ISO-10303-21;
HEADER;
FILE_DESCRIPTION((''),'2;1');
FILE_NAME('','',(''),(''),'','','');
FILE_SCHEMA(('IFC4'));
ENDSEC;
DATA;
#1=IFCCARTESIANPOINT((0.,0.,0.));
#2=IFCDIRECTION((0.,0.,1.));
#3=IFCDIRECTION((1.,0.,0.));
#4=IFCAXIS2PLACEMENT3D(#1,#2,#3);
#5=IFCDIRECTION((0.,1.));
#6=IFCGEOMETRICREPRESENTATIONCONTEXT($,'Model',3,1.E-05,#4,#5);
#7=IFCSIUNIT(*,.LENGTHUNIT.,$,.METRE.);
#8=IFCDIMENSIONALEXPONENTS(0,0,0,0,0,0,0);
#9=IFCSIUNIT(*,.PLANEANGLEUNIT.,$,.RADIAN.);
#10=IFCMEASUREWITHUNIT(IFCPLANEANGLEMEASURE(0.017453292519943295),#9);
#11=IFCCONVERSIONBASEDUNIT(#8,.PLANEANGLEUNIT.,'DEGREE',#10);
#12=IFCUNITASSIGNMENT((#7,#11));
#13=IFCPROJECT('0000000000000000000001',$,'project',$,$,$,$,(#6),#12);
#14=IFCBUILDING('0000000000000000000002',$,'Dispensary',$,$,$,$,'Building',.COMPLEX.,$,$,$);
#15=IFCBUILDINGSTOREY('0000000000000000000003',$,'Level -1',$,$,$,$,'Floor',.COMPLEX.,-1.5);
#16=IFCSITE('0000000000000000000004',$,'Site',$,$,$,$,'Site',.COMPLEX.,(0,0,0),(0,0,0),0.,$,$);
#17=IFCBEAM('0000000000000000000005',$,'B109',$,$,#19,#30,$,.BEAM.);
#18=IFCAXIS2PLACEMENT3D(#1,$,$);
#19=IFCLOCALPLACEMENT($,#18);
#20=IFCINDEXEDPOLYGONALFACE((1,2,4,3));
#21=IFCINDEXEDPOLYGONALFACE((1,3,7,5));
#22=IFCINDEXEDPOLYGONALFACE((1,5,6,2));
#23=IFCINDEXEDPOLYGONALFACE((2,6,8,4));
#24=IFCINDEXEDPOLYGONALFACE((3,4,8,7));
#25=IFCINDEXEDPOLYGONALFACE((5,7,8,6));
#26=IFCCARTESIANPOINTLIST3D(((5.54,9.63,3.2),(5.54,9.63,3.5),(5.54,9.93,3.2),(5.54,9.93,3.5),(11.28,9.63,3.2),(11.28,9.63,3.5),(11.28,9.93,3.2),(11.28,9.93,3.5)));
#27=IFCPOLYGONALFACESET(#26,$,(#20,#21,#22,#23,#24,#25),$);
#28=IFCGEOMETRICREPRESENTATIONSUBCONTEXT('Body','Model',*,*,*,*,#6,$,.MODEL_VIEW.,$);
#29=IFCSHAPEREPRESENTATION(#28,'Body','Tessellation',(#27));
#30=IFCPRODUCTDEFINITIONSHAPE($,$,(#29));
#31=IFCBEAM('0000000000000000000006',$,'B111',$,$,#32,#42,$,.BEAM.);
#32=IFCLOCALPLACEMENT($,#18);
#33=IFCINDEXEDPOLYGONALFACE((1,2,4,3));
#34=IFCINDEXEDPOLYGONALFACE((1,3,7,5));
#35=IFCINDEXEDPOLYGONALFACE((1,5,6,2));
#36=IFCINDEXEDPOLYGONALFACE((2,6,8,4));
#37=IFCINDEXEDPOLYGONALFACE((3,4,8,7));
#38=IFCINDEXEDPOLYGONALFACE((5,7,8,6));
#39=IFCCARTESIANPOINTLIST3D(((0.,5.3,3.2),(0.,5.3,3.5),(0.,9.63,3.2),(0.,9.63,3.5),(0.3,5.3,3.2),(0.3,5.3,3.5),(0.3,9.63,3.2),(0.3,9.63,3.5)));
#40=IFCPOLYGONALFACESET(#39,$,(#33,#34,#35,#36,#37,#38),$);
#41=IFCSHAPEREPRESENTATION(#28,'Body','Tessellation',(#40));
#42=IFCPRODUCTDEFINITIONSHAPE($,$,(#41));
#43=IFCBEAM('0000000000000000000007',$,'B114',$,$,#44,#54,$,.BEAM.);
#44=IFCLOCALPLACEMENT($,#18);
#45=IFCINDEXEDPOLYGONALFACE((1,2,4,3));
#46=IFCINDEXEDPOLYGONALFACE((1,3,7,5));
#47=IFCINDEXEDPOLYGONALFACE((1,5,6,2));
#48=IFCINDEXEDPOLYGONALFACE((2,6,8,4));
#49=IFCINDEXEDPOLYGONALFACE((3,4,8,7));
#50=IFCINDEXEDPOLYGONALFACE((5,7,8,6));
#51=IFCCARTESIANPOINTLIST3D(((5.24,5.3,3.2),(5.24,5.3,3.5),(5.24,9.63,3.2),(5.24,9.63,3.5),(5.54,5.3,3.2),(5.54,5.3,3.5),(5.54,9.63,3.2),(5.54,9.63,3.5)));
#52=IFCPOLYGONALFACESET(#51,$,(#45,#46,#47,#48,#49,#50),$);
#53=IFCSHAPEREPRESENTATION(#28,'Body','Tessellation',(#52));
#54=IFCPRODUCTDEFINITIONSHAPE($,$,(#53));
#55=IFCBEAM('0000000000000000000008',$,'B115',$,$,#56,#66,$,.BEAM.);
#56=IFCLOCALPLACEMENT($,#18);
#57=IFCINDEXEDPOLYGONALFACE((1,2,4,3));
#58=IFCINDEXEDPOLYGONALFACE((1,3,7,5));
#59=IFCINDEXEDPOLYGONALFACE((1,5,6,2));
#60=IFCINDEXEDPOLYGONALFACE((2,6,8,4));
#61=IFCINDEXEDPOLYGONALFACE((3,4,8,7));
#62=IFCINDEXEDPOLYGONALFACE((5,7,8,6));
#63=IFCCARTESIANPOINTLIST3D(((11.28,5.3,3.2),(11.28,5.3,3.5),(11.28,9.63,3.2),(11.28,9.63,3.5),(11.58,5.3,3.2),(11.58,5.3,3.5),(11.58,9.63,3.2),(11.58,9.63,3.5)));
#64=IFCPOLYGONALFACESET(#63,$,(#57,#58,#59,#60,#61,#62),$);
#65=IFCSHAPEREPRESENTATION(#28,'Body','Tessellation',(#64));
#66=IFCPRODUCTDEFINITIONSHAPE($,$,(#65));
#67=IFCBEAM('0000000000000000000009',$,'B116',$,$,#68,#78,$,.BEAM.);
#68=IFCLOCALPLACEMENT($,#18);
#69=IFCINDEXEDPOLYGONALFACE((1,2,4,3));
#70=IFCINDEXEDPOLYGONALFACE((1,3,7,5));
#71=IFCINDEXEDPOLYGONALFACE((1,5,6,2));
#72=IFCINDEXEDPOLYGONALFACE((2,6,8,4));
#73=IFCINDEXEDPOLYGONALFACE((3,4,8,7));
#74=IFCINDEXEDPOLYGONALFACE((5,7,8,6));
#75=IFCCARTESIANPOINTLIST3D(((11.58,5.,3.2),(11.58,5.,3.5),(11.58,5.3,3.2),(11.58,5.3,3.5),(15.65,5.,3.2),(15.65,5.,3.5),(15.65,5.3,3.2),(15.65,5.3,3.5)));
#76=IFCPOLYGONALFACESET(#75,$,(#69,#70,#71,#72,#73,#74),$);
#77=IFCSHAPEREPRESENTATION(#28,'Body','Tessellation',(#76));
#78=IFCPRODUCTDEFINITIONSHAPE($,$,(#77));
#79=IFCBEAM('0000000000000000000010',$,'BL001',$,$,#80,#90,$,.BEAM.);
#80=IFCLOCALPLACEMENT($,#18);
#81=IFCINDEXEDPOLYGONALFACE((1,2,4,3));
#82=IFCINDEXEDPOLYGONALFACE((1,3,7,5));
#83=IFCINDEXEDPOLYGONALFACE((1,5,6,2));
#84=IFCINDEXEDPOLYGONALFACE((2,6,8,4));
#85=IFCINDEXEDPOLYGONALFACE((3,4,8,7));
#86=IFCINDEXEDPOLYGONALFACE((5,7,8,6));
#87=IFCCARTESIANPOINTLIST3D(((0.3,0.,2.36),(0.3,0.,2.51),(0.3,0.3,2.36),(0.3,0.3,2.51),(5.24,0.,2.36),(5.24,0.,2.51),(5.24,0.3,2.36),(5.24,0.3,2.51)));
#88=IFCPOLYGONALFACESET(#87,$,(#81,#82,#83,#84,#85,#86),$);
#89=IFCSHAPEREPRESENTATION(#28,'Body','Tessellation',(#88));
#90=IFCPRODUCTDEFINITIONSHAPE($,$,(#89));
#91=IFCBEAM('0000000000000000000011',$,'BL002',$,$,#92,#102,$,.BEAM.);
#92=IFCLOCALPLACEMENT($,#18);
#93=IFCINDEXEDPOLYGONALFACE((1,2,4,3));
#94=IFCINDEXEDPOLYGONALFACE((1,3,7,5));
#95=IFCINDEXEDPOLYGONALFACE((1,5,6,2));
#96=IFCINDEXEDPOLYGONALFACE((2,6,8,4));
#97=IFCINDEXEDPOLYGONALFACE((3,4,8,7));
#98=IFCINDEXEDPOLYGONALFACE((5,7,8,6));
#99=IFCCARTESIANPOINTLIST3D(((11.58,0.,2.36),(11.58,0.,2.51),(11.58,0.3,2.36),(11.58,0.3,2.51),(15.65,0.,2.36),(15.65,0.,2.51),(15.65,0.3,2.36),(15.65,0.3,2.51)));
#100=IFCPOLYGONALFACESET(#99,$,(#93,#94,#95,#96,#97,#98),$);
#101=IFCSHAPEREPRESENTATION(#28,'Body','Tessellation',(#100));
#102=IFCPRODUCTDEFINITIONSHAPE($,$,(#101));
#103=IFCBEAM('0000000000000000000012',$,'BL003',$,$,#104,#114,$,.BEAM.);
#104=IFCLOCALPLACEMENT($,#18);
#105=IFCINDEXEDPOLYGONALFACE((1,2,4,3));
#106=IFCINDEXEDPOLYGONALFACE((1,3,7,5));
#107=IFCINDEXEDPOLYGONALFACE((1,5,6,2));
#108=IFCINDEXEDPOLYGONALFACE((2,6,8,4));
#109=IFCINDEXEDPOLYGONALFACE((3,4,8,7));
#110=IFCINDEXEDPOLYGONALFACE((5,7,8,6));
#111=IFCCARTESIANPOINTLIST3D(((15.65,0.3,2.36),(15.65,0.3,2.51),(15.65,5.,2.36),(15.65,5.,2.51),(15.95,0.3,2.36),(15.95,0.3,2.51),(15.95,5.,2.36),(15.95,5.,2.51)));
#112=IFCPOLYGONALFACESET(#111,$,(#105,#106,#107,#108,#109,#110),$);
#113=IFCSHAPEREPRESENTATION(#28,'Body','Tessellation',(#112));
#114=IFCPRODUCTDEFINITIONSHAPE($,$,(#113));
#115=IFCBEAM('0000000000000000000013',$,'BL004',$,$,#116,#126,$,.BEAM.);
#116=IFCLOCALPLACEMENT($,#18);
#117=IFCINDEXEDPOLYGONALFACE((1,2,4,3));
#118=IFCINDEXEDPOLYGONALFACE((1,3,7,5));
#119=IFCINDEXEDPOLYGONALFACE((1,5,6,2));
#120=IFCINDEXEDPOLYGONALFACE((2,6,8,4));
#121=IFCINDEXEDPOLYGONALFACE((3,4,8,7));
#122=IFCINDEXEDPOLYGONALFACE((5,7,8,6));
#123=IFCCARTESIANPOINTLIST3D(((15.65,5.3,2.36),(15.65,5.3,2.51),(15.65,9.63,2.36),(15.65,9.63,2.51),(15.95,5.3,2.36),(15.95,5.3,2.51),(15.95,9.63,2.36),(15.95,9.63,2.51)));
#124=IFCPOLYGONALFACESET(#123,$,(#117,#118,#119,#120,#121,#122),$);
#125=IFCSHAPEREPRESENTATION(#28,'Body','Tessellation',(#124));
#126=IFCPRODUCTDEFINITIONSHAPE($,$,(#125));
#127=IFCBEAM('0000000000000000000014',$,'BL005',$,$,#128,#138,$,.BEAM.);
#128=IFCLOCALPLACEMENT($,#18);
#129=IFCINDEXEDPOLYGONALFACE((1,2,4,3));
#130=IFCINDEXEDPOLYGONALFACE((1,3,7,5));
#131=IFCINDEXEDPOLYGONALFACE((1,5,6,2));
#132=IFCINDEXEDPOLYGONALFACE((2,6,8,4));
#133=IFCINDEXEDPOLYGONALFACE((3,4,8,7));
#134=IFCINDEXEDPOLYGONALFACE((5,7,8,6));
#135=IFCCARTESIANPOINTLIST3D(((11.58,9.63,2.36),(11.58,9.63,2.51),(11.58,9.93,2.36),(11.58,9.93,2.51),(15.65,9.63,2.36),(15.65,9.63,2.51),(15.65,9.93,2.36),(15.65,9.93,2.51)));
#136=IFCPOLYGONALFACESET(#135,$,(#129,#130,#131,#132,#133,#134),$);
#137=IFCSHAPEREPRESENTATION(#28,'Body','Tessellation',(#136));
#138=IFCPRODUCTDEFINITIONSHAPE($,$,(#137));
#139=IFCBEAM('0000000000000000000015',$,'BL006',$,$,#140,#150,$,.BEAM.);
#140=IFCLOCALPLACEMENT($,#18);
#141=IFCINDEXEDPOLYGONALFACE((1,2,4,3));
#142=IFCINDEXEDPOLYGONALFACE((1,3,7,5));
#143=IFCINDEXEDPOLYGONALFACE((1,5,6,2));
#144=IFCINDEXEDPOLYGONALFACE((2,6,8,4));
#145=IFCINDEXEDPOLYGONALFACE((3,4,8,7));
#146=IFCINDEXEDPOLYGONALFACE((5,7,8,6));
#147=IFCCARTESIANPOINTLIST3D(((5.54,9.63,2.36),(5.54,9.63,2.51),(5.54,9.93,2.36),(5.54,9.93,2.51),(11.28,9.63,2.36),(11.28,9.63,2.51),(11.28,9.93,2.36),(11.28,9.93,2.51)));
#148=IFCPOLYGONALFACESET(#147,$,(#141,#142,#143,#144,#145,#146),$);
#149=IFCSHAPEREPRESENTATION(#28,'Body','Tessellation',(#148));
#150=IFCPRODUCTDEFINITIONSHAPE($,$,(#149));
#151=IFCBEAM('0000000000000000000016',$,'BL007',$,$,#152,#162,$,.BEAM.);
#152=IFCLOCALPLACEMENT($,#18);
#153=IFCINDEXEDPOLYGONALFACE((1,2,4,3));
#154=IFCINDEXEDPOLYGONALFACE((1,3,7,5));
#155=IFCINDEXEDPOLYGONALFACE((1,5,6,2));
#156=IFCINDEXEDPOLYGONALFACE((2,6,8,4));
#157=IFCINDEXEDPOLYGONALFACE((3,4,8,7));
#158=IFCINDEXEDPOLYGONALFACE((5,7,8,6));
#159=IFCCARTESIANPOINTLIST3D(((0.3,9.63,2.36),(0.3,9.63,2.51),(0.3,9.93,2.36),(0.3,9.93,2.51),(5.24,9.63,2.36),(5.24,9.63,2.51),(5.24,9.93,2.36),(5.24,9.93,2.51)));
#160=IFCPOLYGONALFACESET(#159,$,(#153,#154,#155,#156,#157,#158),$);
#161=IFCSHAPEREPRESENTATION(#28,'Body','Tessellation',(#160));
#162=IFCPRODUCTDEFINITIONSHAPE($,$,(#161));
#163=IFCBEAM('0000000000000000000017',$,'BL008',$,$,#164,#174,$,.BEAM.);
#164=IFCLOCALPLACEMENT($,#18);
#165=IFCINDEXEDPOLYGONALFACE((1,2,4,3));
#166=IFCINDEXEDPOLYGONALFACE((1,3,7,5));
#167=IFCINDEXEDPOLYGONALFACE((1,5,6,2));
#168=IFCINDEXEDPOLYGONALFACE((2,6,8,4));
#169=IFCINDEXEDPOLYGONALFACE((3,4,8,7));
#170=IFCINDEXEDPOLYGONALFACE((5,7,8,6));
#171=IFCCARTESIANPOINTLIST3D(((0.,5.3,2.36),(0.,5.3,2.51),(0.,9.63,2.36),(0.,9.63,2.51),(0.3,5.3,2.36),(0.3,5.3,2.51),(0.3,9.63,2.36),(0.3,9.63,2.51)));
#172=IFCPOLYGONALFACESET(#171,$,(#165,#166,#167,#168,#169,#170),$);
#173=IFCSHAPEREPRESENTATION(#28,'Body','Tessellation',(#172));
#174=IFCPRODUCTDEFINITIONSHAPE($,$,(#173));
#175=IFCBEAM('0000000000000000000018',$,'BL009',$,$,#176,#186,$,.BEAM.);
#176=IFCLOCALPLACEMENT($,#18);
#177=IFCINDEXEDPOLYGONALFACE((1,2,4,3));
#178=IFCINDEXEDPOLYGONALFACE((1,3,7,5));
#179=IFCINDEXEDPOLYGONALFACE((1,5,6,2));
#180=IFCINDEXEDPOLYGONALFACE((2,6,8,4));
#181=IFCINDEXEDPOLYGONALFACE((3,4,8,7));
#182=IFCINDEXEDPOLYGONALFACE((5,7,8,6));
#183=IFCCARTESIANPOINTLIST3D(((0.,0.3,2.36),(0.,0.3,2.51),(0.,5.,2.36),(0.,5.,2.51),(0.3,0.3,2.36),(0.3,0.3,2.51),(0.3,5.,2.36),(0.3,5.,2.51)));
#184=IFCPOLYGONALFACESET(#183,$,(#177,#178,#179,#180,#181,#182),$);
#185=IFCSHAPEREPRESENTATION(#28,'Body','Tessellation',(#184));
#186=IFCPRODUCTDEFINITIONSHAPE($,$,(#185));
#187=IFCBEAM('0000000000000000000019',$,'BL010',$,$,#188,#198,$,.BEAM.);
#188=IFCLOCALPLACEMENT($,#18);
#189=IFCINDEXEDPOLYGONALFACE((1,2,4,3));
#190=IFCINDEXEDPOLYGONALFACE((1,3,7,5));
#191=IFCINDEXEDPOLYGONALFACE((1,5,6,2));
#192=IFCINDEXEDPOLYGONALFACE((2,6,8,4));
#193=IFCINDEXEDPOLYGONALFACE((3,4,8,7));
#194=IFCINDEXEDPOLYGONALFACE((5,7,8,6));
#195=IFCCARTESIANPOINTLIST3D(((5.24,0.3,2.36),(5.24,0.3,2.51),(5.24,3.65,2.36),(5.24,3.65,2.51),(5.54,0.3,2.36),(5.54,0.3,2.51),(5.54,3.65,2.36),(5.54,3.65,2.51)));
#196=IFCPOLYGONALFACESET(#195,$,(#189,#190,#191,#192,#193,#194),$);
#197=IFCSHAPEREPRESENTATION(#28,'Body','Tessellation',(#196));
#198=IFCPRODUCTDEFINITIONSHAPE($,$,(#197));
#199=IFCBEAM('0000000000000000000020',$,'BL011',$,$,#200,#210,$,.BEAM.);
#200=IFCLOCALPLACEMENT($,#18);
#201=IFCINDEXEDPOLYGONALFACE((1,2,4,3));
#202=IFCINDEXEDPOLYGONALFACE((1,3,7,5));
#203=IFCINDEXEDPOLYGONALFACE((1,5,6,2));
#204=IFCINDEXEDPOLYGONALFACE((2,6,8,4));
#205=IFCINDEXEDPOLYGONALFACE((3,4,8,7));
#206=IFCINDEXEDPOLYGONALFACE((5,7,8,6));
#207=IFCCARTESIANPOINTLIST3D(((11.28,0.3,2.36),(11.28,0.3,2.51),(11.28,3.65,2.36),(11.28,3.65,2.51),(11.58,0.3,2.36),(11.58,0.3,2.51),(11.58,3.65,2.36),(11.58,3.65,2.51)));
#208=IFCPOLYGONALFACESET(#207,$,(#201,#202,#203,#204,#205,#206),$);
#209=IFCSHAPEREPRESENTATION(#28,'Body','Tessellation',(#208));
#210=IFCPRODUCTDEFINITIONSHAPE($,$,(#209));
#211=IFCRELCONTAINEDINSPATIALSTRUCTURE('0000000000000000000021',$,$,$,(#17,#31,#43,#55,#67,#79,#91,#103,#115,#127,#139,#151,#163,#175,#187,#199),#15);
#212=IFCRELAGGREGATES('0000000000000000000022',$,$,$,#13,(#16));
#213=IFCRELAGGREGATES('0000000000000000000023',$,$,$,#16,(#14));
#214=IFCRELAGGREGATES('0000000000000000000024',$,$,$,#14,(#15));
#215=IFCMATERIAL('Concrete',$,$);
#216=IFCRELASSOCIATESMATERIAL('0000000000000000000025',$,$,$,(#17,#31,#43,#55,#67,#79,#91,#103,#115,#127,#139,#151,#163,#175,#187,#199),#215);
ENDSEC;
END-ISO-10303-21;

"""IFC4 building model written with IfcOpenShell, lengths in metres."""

from ifc_helpers import new_model, entity, si_unit, converted_unit, direction, frame, frame_2d, origin_with_axes, place, context, subcontext, project, spatial, rectangle, extrude, material, element, save


model = new_model("IFC4")

# Units and contexts
model_context = context("Model", 3, precision=1e-05, world=origin_with_axes(), true_north=direction((0.0, 1.0)))
body_context = subcontext(model_context, "Body", "Model", "MODEL_VIEW")
ifc_project = project(units=[si_unit("LENGTHUNIT", "METRE"), converted_unit("PLANEANGLEUNIT", "DEGREE", entity("IfcPlaneAngleMeasure", 0.017453292519943295), si_unit("PLANEANGLEUNIT", "RADIAN"), dimensions=[0, 0, 0, 0, 0, 0, 0])], contexts=[model_context])

# Site, building, storey
site = spatial("IfcSite", under=ifc_project, Name="Site", LongName="Site", CompositionType="COMPLEX", RefLatitude=(0, 0, 0), RefLongitude=(0, 0, 0), RefElevation=0.0)
building = spatial("IfcBuilding", under=site, Name="Dispensary", LongName="Building", CompositionType="COMPLEX")
storey = spatial("IfcBuildingStorey", under=building, Name="Level -1", LongName="Floor", CompositionType="COMPLEX", Elevation=-1.5)

# Shared definitions
ifc_material = material(Name="Concrete")
placement = place(None, origin_with_axes())

# Beams
element("IfcBeam", 1, at=placement, inside=storey, material=ifc_material, Name="B109", PredefinedType="BEAM", context=body_context, shape_type="SweptSolid", body=[
    extrude(rectangle(XDim=0.3, YDim=0.3, at=frame_2d((0.0, 0.0), x_axis=(0.0, 1.0))), frame((11.28, 9.78, 3.35), z_axis=(-1.0, 0.0, 0.0), x_axis=(0.0, 0.0, -1.0)), (0.0, 0.0, 1.0), 5.74),
])
element("IfcBeam", 2, at=placement, inside=storey, material=ifc_material, Name="B111", PredefinedType="BEAM", context=body_context, shape_type="SweptSolid", body=[
    extrude(rectangle(XDim=0.3, YDim=0.3, at=frame_2d((0.0, 0.0), x_axis=(0.0, 1.0))), frame((0.15, 9.63, 3.35), z_axis=(0.0, -1.0, 0.0), x_axis=(0.0, 0.0, -1.0)), (0.0, 0.0, 1.0), 4.33),
])
element("IfcBeam", 3, at=placement, inside=storey, material=ifc_material, Name="B114", PredefinedType="BEAM", context=body_context, shape_type="SweptSolid", body=[
    extrude(rectangle(XDim=0.3, YDim=0.3, at=frame_2d((0.0, 0.0), x_axis=(0.0, 1.0))), frame((5.39, 9.63, 3.35), z_axis=(0.0, -1.0, 0.0), x_axis=(0.0, 0.0, -1.0)), (0.0, 0.0, 1.0), 4.33),
])
element("IfcBeam", 4, at=placement, inside=storey, material=ifc_material, Name="B115", PredefinedType="BEAM", context=body_context, shape_type="SweptSolid", body=[
    extrude(rectangle(XDim=0.3, YDim=0.3, at=frame_2d((0.0, 0.0), x_axis=(0.0, 1.0))), frame((11.43, 9.63, 3.35), z_axis=(0.0, -1.0, 0.0), x_axis=(0.0, 0.0, -1.0)), (0.0, 0.0, 1.0), 4.33),
])
element("IfcBeam", 5, at=placement, inside=storey, material=ifc_material, Name="B116", PredefinedType="BEAM", context=body_context, shape_type="SweptSolid", body=[
    extrude(rectangle(XDim=0.3, YDim=0.3, at=frame_2d((0.0, 0.0), x_axis=(0.0, 1.0))), frame((15.65, 5.15, 3.35), z_axis=(-1.0, 0.0, 0.0), x_axis=(0.0, 0.0, -1.0)), (0.0, 0.0, 1.0), 4.07),
])
element("IfcBeam", 6, at=placement, inside=storey, material=ifc_material, Name="BL001", PredefinedType="BEAM", context=body_context, shape_type="SweptSolid", body=[
    extrude(rectangle(XDim=0.3, YDim=0.15, at=frame_2d((0.0, 0.0), x_axis=(0.0, 1.0))), frame((0.3, 0.15, 2.435), z_axis=(1.0, 0.0, 0.0), x_axis=(0.0, 0.0, -1.0)), (0.0, 0.0, 1.0), 4.94),
])
element("IfcBeam", 7, at=placement, inside=storey, material=ifc_material, Name="BL002", PredefinedType="BEAM", context=body_context, shape_type="SweptSolid", body=[
    extrude(rectangle(XDim=0.3, YDim=0.15, at=frame_2d((0.0, 0.0), x_axis=(0.0, 1.0))), frame((11.58, 0.15, 2.435), z_axis=(1.0, 0.0, 0.0), x_axis=(0.0, 0.0, -1.0)), (0.0, 0.0, 1.0), 4.07),
])
element("IfcBeam", 8, at=placement, inside=storey, material=ifc_material, Name="BL003", PredefinedType="BEAM", context=body_context, shape_type="SweptSolid", body=[
    extrude(rectangle(XDim=0.3, YDim=0.15, at=frame_2d((0.0, 0.0), x_axis=(0.0, 1.0))), frame((15.8, 0.3, 2.435), z_axis=(0.0, 1.0, 0.0), x_axis=(0.0, 0.0, -1.0)), (0.0, 0.0, 1.0), 4.7),
])
element("IfcBeam", 9, at=placement, inside=storey, material=ifc_material, Name="BL004", PredefinedType="BEAM", context=body_context, shape_type="SweptSolid", body=[
    extrude(rectangle(XDim=0.3, YDim=0.15, at=frame_2d((0.0, 0.0), x_axis=(0.0, 1.0))), frame((15.8, 5.3, 2.435), z_axis=(0.0, 1.0, 0.0), x_axis=(0.0, 0.0, -1.0)), (0.0, 0.0, 1.0), 4.33),
])
element("IfcBeam", 10, at=placement, inside=storey, material=ifc_material, Name="BL005", PredefinedType="BEAM", context=body_context, shape_type="SweptSolid", body=[
    extrude(rectangle(XDim=0.3, YDim=0.15, at=frame_2d((0.0, 0.0), x_axis=(0.0, 1.0))), frame((15.65, 9.78, 2.435), z_axis=(-1.0, 0.0, 0.0), x_axis=(0.0, 0.0, -1.0)), (0.0, 0.0, 1.0), 4.07),
])
element("IfcBeam", 11, at=placement, inside=storey, material=ifc_material, Name="BL006", PredefinedType="BEAM", context=body_context, shape_type="SweptSolid", body=[
    extrude(rectangle(XDim=0.3, YDim=0.15, at=frame_2d((0.0, 0.0), x_axis=(0.0, 1.0))), frame((11.28, 9.78, 2.435), z_axis=(-1.0, 0.0, 0.0), x_axis=(0.0, 0.0, -1.0)), (0.0, 0.0, 1.0), 5.74),
])
element("IfcBeam", 12, at=placement, inside=storey, material=ifc_material, Name="BL007", PredefinedType="BEAM", context=body_context, shape_type="SweptSolid", body=[
    extrude(rectangle(XDim=0.3, YDim=0.15, at=frame_2d((0.0, 0.0), x_axis=(0.0, 1.0))), frame((5.24, 9.78, 2.435), z_axis=(-1.0, 0.0, 0.0), x_axis=(0.0, 0.0, -1.0)), (0.0, 0.0, 1.0), 4.94),
])
element("IfcBeam", 13, at=placement, inside=storey, material=ifc_material, Name="BL008", PredefinedType="BEAM", context=body_context, shape_type="SweptSolid", body=[
    extrude(rectangle(XDim=0.3, YDim=0.15, at=frame_2d((0.0, 0.0), x_axis=(0.0, 1.0))), frame((0.15, 9.63, 2.435), z_axis=(0.0, -1.0, 0.0), x_axis=(0.0, 0.0, -1.0)), (0.0, 0.0, 1.0), 4.33),
])
element("IfcBeam", 14, at=placement, inside=storey, material=ifc_material, Name="BL009", PredefinedType="BEAM", context=body_context, shape_type="SweptSolid", body=[
    extrude(rectangle(XDim=0.3, YDim=0.15, at=frame_2d((0.0, 0.0), x_axis=(0.0, 1.0))), frame((0.15, 5.0, 2.435), z_axis=(0.0, -1.0, 0.0), x_axis=(0.0, 0.0, -1.0)), (0.0, 0.0, 1.0), 4.7),
])
element("IfcBeam", 15, at=placement, inside=storey, material=ifc_material, Name="BL010", PredefinedType="BEAM", context=body_context, shape_type="SweptSolid", body=[
    extrude(rectangle(XDim=0.3, YDim=0.15, at=frame_2d((0.0, 0.0), x_axis=(0.0, 1.0))), frame((5.39, 0.3, 2.435), z_axis=(0.0, 1.0, 0.0), x_axis=(0.0, 0.0, -1.0)), (0.0, 0.0, 1.0), 3.35),
])
element("IfcBeam", 16, at=placement, inside=storey, material=ifc_material, Name="BL011", PredefinedType="BEAM", context=body_context, shape_type="SweptSolid", body=[
    extrude(rectangle(XDim=0.3, YDim=0.15, at=frame_2d((0.0, 0.0), x_axis=(0.0, 1.0))), frame((11.43, 0.3, 2.435), z_axis=(0.0, 1.0, 0.0), x_axis=(0.0, 0.0, -1.0)), (0.0, 0.0, 1.0), 3.35),
])

save(model, "model.ifc")
